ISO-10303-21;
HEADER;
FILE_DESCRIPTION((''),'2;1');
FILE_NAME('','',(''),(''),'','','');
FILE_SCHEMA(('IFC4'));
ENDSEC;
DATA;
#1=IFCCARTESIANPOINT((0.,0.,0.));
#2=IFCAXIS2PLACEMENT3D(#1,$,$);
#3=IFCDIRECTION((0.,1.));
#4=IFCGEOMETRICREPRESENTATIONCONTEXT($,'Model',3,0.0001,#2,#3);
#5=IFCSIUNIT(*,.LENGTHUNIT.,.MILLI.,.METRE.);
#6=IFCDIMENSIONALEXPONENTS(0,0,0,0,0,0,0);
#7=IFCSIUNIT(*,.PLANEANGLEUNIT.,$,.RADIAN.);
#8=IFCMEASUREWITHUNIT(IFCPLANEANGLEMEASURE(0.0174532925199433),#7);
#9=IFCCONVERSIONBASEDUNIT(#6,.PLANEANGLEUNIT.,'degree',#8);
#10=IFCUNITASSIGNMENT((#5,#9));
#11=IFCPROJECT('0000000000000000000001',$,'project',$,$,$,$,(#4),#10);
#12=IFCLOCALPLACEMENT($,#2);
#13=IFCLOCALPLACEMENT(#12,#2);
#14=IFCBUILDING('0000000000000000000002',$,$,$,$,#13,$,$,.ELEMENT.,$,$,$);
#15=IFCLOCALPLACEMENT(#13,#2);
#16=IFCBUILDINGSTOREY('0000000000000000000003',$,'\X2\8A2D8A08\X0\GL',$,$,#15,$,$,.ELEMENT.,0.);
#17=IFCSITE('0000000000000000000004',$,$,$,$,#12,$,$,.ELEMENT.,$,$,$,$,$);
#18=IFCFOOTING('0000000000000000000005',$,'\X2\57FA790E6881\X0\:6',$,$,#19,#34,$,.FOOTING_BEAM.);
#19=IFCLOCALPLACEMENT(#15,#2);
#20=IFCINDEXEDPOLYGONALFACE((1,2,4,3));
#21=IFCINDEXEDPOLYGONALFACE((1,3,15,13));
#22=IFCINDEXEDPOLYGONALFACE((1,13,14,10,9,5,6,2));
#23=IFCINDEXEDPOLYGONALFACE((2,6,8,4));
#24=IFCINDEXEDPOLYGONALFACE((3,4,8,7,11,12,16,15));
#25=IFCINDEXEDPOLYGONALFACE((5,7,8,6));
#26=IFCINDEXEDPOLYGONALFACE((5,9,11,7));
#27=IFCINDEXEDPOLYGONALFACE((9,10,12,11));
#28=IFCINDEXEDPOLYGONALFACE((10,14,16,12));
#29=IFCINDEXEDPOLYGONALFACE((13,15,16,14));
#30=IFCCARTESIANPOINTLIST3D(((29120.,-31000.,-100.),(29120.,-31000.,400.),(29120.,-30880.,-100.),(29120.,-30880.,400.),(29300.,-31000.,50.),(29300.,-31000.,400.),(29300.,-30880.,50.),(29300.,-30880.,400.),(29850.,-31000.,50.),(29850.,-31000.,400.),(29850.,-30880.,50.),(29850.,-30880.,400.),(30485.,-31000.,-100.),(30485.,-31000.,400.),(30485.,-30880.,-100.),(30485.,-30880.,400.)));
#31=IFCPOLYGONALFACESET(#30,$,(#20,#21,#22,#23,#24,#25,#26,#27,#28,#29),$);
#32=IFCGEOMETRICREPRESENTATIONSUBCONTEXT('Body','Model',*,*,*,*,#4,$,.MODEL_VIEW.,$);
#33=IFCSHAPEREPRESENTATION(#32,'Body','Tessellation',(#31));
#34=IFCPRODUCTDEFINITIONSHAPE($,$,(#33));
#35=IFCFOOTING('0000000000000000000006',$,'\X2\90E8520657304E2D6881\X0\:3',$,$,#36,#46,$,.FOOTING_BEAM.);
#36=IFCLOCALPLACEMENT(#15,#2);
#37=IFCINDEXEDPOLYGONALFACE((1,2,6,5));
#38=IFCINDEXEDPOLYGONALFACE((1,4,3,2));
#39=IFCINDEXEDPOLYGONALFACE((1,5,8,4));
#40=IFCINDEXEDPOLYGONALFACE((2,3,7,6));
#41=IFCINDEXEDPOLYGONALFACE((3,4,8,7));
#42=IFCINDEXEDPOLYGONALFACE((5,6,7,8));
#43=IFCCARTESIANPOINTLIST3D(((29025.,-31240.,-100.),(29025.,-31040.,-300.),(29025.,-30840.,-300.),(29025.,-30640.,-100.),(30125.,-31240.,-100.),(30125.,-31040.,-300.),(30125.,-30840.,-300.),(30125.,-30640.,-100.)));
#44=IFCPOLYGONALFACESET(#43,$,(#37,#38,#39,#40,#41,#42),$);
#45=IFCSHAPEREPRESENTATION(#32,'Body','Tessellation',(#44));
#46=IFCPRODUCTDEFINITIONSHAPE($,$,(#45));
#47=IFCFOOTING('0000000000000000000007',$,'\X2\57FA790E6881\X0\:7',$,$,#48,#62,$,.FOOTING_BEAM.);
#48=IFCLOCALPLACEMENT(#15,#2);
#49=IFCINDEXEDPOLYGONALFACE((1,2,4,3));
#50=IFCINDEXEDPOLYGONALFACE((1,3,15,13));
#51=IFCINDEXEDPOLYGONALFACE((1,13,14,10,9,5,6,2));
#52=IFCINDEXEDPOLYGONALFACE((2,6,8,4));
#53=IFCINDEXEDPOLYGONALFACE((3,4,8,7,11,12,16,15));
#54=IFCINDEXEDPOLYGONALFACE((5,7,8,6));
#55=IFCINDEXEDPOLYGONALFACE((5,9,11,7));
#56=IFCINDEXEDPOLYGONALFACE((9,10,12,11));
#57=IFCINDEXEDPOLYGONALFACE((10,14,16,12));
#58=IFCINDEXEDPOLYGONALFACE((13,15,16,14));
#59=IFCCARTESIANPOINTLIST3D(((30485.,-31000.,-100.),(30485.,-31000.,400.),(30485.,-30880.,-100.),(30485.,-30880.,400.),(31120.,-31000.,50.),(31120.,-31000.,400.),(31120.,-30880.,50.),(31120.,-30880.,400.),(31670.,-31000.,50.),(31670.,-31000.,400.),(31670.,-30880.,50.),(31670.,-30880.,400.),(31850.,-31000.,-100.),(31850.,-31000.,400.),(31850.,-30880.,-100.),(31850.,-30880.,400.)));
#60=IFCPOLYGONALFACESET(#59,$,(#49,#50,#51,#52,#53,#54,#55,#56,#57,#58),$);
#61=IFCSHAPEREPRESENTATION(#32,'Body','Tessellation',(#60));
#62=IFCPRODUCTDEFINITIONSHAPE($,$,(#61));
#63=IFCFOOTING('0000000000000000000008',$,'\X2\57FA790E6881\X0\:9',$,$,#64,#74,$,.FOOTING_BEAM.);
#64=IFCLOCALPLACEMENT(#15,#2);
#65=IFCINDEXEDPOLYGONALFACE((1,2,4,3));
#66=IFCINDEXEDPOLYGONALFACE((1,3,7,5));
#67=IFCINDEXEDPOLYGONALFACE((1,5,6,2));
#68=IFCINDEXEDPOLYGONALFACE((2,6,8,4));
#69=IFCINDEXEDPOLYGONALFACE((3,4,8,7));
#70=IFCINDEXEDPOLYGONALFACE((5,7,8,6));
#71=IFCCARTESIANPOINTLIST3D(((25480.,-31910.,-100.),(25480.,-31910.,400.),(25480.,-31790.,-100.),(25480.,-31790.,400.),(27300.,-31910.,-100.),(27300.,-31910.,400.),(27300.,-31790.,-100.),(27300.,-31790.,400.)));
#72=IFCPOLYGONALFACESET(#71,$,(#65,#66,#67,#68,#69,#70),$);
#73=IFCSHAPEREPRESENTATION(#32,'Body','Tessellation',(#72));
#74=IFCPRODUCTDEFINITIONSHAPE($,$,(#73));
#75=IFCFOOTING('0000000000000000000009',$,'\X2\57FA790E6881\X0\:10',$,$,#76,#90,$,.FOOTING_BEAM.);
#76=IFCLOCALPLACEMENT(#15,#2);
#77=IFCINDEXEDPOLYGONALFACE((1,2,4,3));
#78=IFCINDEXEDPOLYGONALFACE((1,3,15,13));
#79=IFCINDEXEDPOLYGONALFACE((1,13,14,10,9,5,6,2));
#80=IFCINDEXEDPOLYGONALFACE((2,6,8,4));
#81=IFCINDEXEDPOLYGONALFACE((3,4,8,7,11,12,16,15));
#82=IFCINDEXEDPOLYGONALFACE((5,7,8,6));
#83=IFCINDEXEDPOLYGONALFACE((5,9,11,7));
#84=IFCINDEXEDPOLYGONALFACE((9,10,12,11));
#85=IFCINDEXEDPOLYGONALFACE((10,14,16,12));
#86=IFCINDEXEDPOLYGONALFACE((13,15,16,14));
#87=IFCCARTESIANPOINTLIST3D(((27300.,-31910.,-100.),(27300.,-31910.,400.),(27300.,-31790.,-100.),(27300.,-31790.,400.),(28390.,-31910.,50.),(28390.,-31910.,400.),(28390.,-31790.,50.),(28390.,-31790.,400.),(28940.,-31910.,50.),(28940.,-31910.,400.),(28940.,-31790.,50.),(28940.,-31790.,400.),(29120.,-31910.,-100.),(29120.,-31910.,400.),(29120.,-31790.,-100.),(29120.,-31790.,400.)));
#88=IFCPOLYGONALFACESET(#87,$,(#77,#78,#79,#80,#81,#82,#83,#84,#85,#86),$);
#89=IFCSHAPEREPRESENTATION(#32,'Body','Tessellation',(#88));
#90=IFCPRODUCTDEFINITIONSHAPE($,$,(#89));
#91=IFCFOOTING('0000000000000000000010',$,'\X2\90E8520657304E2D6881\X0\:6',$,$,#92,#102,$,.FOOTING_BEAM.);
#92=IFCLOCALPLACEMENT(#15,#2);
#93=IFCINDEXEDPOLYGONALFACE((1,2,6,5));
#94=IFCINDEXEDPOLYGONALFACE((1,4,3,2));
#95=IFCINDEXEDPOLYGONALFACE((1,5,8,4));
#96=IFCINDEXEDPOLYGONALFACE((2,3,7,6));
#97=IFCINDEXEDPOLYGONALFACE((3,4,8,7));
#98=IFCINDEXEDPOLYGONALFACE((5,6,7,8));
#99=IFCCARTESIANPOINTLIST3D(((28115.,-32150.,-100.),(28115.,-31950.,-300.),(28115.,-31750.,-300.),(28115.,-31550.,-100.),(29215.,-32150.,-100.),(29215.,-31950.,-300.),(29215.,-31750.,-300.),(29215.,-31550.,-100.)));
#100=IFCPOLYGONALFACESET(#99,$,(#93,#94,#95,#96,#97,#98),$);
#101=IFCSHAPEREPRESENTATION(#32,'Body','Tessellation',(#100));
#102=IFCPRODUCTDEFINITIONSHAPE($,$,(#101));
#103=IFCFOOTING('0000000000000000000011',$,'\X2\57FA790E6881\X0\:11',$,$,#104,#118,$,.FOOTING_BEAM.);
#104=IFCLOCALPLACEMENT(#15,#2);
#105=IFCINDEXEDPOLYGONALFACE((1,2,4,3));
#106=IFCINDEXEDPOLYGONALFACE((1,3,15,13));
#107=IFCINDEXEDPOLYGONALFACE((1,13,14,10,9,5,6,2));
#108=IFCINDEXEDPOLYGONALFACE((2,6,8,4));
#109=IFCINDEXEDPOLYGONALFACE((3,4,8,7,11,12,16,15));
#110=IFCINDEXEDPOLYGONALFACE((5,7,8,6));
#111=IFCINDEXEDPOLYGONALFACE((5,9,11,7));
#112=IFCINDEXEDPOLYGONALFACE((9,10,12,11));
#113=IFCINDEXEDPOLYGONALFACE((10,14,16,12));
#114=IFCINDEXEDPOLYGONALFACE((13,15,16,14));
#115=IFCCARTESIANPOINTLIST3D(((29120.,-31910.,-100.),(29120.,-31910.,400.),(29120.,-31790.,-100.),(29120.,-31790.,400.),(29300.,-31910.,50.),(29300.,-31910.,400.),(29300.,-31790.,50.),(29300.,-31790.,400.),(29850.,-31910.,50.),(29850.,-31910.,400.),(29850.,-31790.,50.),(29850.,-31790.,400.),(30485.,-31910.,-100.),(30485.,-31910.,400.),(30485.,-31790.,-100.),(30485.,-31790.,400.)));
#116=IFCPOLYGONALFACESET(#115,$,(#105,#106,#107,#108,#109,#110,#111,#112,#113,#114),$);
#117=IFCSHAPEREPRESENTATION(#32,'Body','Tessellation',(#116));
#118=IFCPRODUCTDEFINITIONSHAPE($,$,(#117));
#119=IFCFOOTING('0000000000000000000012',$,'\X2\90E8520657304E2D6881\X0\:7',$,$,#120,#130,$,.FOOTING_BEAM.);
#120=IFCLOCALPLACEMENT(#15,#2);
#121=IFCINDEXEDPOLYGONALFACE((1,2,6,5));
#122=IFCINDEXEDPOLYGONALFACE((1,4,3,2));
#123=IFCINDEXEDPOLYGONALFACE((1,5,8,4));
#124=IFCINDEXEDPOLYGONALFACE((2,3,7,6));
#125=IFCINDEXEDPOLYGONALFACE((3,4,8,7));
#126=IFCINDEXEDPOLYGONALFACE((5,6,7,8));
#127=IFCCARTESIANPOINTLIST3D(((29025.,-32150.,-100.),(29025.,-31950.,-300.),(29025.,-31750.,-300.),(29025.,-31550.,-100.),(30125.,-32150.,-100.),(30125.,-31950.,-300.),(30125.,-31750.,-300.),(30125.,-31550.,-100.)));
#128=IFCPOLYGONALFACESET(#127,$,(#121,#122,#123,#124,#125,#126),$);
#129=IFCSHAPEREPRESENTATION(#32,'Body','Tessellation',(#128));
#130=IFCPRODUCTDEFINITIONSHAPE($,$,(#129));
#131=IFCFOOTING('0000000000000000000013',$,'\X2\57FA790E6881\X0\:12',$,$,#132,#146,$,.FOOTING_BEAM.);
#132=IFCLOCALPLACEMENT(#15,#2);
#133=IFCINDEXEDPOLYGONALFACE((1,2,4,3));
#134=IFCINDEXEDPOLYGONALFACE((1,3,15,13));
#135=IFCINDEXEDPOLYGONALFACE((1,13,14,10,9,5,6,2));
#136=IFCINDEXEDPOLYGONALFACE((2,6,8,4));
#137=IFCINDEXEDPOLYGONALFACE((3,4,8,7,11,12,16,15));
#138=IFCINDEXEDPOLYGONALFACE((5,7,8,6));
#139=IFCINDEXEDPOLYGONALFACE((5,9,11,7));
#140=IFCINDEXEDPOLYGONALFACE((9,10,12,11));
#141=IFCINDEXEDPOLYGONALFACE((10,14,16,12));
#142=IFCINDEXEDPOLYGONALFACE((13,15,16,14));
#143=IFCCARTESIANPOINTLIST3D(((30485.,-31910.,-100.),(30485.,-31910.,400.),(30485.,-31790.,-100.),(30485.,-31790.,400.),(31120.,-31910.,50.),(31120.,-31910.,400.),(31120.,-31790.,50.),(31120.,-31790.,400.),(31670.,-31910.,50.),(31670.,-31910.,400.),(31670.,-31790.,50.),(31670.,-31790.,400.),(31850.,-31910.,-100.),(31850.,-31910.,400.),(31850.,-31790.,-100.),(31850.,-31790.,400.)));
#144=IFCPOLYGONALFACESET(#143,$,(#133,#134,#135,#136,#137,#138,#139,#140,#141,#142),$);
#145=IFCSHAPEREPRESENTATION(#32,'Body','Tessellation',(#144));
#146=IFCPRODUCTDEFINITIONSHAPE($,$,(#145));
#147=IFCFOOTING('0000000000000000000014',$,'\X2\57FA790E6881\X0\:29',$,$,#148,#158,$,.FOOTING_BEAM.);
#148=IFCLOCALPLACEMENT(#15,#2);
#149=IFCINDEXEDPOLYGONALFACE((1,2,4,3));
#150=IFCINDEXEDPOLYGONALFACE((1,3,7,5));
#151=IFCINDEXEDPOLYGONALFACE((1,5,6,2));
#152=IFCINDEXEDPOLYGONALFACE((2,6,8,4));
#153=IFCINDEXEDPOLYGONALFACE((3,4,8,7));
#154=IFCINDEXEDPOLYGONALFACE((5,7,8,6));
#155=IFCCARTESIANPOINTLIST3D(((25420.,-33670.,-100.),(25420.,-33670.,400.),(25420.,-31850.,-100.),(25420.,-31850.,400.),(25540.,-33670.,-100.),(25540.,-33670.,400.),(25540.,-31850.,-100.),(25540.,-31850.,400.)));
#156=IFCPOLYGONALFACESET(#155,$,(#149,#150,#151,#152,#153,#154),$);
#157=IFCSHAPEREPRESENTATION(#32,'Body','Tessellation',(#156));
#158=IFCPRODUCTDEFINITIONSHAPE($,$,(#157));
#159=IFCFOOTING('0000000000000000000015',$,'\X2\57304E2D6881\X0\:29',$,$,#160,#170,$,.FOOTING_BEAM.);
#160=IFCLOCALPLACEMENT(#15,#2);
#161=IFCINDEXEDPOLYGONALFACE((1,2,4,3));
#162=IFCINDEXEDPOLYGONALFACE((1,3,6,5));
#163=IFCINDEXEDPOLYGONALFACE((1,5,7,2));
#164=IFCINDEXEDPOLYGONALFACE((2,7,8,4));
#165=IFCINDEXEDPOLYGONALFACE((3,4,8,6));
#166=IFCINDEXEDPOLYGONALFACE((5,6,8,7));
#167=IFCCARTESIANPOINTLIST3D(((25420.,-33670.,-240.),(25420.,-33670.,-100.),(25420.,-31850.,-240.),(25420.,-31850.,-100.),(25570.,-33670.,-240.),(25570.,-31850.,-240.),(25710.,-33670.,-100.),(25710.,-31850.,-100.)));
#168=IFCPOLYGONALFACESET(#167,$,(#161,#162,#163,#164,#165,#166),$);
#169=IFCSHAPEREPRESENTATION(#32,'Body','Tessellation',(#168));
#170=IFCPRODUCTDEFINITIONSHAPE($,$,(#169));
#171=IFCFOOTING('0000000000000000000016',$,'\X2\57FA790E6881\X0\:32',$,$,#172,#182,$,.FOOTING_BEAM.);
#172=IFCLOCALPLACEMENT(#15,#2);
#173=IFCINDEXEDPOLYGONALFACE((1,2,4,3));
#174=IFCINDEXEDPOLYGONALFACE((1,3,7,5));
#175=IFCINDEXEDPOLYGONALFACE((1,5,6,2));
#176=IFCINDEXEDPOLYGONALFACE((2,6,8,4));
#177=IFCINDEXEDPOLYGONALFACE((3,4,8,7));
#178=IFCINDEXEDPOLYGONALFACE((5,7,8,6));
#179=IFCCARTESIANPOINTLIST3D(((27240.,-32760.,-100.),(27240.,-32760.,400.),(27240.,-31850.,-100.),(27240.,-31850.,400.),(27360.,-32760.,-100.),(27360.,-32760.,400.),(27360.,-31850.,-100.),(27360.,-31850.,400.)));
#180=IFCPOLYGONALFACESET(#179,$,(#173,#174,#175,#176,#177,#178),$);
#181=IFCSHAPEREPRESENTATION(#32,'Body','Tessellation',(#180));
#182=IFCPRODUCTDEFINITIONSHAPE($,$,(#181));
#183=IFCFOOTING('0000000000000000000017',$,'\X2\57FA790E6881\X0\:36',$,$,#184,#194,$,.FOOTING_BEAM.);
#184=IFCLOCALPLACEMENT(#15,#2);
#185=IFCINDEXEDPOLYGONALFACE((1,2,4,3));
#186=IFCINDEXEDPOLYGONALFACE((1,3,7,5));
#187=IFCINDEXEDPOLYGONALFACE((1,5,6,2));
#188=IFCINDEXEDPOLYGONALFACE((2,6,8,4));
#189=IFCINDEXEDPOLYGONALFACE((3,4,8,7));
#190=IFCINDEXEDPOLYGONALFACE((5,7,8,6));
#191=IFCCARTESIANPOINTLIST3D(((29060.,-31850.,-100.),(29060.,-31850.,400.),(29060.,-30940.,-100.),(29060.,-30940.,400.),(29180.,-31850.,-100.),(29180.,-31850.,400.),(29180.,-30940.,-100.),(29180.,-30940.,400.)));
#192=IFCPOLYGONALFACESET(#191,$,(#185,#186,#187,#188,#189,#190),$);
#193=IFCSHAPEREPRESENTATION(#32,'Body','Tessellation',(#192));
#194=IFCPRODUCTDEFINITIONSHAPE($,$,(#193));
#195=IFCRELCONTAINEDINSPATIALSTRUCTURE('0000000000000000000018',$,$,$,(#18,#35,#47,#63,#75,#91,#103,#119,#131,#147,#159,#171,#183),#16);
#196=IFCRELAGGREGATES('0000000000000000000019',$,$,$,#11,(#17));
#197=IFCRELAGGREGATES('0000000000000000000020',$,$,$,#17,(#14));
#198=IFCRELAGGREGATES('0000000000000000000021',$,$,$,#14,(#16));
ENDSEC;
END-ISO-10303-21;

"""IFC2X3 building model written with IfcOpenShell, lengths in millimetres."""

from ifc_helpers import new_model, entity, si_unit, converted_unit, direction, frame, origin, origin_with_axes, origin_2d, place, context, subcontext, project, spatial, polyline, rectangle, outline, extrude, boolean, element, save


model = new_model("IFC2X3")

# Units and contexts
model_context = context("Model", 3, precision=0.0001, world=origin(), true_north=direction((0.0, 1.0)))
body_context = subcontext(model_context, "Body", "Model", "MODEL_VIEW")
ifc_project = project(units=[si_unit("LENGTHUNIT", "METRE", prefix="MILLI"), converted_unit("PLANEANGLEUNIT", "degree", entity("IfcPlaneAngleMeasure", 0.0174532925199433), si_unit("PLANEANGLEUNIT", "RADIAN"), dimensions=[0, 0, 0, 0, 0, 0, 0])], contexts=[model_context])

# Site, building, storey
site_placement = place(None, origin())
site = spatial("IfcSite", under=ifc_project, at=site_placement, CompositionType="ELEMENT")
building_placement = place(site_placement, origin())
building = spatial("IfcBuilding", under=site, at=building_placement, CompositionType="ELEMENT")
storey_placement = place(building_placement, origin())
storey = spatial("IfcBuildingStorey", under=building, at=storey_placement, Name="設計GL", CompositionType="ELEMENT", Elevation=0.0)

# Footings
footing_1_placement = place(storey_placement, frame((29120.0, -30940.0, 150.0), z_axis=(1.0, 0.0, 0.0), x_axis=(0.0, 1.0, 0.0)))
element("IfcFooting", 1, at=footing_1_placement, inside=storey, Name="基礎梁:6", PredefinedType="FOOTING_BEAM", context=body_context, shape_type="CSG", body=[
    boolean("DIFFERENCE", extrude(rectangle(XDim=120.0, YDim=500.0, at=origin_2d()), origin_with_axes(), (0.0, 0.0, 1.0), 1365.0), extrude(rectangle(XDim=124.0, YDim=350.0, at=origin_2d()), frame((0.0, 75.0, 180.0), z_axis=(0.0, 0.0, 1.0), x_axis=(1.0, 0.0, 0.0)), (0.0, 0.0, 1.0), 550.0)),
])
footing_2_placement = place(storey_placement, frame((29025.0, -30940.0, -300.0), z_axis=(1.0, 0.0, 0.0), x_axis=(0.0, 1.0, 0.0)))
element("IfcFooting", 2, at=footing_2_placement, inside=storey, Name="部分地中梁:3", PredefinedType="FOOTING_BEAM", context=body_context, shape_type="SweptSolid", body=[
    extrude(outline(polyline([(-100.0, 0.0, 0.0), (100.0, 0.0, 0.0), (300.0, 200.0, 0.0), (-300.0, 200.0, 0.0), (-100.0, 0.0, 0.0)])), origin_with_axes(), (0.0, 0.0, 1.0), 1100.0),
])
footing_3_placement = place(storey_placement, frame((30485.0, -30940.0, 150.0), z_axis=(1.0, 0.0, 0.0), x_axis=(0.0, 1.0, 0.0)))
element("IfcFooting", 3, at=footing_3_placement, inside=storey, Name="基礎梁:7", PredefinedType="FOOTING_BEAM", context=body_context, shape_type="CSG", body=[
    boolean("DIFFERENCE", extrude(rectangle(XDim=120.0, YDim=500.0, at=origin_2d()), origin_with_axes(), (0.0, 0.0, 1.0), 1365.0), extrude(rectangle(XDim=124.0, YDim=350.0, at=origin_2d()), frame((0.0, 75.0, 635.0), z_axis=(0.0, 0.0, 1.0), x_axis=(1.0, 0.0, 0.0)), (0.0, 0.0, 1.0), 550.0)),
])
footing_4_placement = place(storey_placement, frame((25480.0, -31850.0, 150.0), z_axis=(1.0, 0.0, 0.0), x_axis=(0.0, 1.0, 0.0)))
element("IfcFooting", 4, at=footing_4_placement, inside=storey, Name="基礎梁:9", PredefinedType="FOOTING_BEAM", context=body_context, shape_type="SolidModel", body=[
    extrude(rectangle(XDim=120.0, YDim=500.0, at=origin_2d()), origin_with_axes(), (0.0, 0.0, 1.0), 1820.0),
])
footing_5_placement = place(storey_placement, frame((27300.0, -31850.0, 150.0), z_axis=(1.0, 0.0, 0.0), x_axis=(0.0, 1.0, 0.0)))
element("IfcFooting", 5, at=footing_5_placement, inside=storey, Name="基礎梁:10", PredefinedType="FOOTING_BEAM", context=body_context, shape_type="CSG", body=[
    boolean("DIFFERENCE", extrude(rectangle(XDim=120.0, YDim=500.0, at=origin_2d()), origin_with_axes(), (0.0, 0.0, 1.0), 1820.0), extrude(rectangle(XDim=124.0, YDim=350.0, at=origin_2d()), frame((0.0, 75.0, 1090.0), z_axis=(0.0, 0.0, 1.0), x_axis=(1.0, 0.0, 0.0)), (0.0, 0.0, 1.0), 550.0)),
])
footing_6_placement = place(storey_placement, frame((28115.0, -31850.0, -300.0), z_axis=(1.0, 0.0, 0.0), x_axis=(0.0, 1.0, 0.0)))
element("IfcFooting", 6, at=footing_6_placement, inside=storey, Name="部分地中梁:6", PredefinedType="FOOTING_BEAM", context=body_context, shape_type="SweptSolid", body=[
    extrude(outline(polyline([(-100.0, 0.0, 0.0), (100.0, 0.0, 0.0), (300.0, 200.0, 0.0), (-300.0, 200.0, 0.0), (-100.0, 0.0, 0.0)])), origin_with_axes(), (0.0, 0.0, 1.0), 1100.0),
])
footing_7_placement = place(storey_placement, frame((29120.0, -31850.0, 150.0), z_axis=(1.0, 0.0, 0.0), x_axis=(0.0, 1.0, 0.0)))
element("IfcFooting", 7, at=footing_7_placement, inside=storey, Name="基礎梁:11", PredefinedType="FOOTING_BEAM", context=body_context, shape_type="CSG", body=[
    boolean("DIFFERENCE", extrude(rectangle(XDim=120.0, YDim=500.0, at=origin_2d()), origin_with_axes(), (0.0, 0.0, 1.0), 1365.0), extrude(rectangle(XDim=124.0, YDim=350.0, at=origin_2d()), frame((0.0, 75.0, 180.0), z_axis=(0.0, 0.0, 1.0), x_axis=(1.0, 0.0, 0.0)), (0.0, 0.0, 1.0), 550.0)),
])
footing_8_placement = place(storey_placement, frame((29025.0, -31850.0, -300.0), z_axis=(1.0, 0.0, 0.0), x_axis=(0.0, 1.0, 0.0)))
element("IfcFooting", 8, at=footing_8_placement, inside=storey, Name="部分地中梁:7", PredefinedType="FOOTING_BEAM", context=body_context, shape_type="SweptSolid", body=[
    extrude(outline(polyline([(-100.0, 0.0, 0.0), (100.0, 0.0, 0.0), (300.0, 200.0, 0.0), (-300.0, 200.0, 0.0), (-100.0, 0.0, 0.0)])), origin_with_axes(), (0.0, 0.0, 1.0), 1100.0),
])
footing_9_placement = place(storey_placement, frame((30485.0, -31850.0, 150.0), z_axis=(1.0, 0.0, 0.0), x_axis=(0.0, 1.0, 0.0)))
element("IfcFooting", 9, at=footing_9_placement, inside=storey, Name="基礎梁:12", PredefinedType="FOOTING_BEAM", context=body_context, shape_type="CSG", body=[
    boolean("DIFFERENCE", extrude(rectangle(XDim=120.0, YDim=500.0, at=origin_2d()), origin_with_axes(), (0.0, 0.0, 1.0), 1365.0), extrude(rectangle(XDim=124.0, YDim=350.0, at=origin_2d()), frame((0.0, 75.0, 635.0), z_axis=(0.0, 0.0, 1.0), x_axis=(1.0, 0.0, 0.0)), (0.0, 0.0, 1.0), 550.0)),
])
footing_10_placement = place(storey_placement, frame((25480.0, -31850.0, 150.0), z_axis=(0.0, -1.0, 0.0), x_axis=(1.0, 0.0, 0.0)))
element("IfcFooting", 10, at=footing_10_placement, inside=storey, Name="基礎梁:29", PredefinedType="FOOTING_BEAM", context=body_context, shape_type="SolidModel", body=[
    extrude(rectangle(XDim=120.0, YDim=500.0, at=origin_2d()), origin_with_axes(), (0.0, 0.0, 1.0), 1820.0),
])
footing_11_placement = place(storey_placement, frame((25420.0, -31850.0, -240.0), z_axis=(0.0, -1.0, 0.0), x_axis=(1.0, 0.0, 0.0)))
element("IfcFooting", 11, at=footing_11_placement, inside=storey, Name="地中梁:29", PredefinedType="FOOTING_BEAM", context=body_context, shape_type="SweptSolid", body=[
    extrude(outline(polyline([(0.0, 0.0, 0.0), (150.0, 0.0, 0.0), (290.0, 140.0, 0.0), (0.0, 140.0, 0.0), (0.0, 0.0, 0.0)])), origin_with_axes(), (0.0, 0.0, 1.0), 1820.0),
])
for number, where, z_axis, x_axis, name in (
    (12, (27300.0, -31850.0, 150.0), (0.0, -1.0, 0.0), (1.0, 0.0, 0.0), "基礎梁:32"),
    (13, (29120.0, -30940.0, 150.0), (0.0, -1.0, 0.0), (1.0, 0.0, 0.0), "基礎梁:36"),
):
    element("IfcFooting", number, at=place(storey_placement, frame(where, z_axis=z_axis, x_axis=x_axis)), inside=storey, Name=name, PredefinedType="FOOTING_BEAM", context=body_context, shape_type="SolidModel", body=[
        extrude(rectangle(XDim=120.0, YDim=500.0, at=origin_2d()), origin_with_axes(), (0.0, 0.0, 1.0), 910.0),
    ])

save(model, "model.ifc")
